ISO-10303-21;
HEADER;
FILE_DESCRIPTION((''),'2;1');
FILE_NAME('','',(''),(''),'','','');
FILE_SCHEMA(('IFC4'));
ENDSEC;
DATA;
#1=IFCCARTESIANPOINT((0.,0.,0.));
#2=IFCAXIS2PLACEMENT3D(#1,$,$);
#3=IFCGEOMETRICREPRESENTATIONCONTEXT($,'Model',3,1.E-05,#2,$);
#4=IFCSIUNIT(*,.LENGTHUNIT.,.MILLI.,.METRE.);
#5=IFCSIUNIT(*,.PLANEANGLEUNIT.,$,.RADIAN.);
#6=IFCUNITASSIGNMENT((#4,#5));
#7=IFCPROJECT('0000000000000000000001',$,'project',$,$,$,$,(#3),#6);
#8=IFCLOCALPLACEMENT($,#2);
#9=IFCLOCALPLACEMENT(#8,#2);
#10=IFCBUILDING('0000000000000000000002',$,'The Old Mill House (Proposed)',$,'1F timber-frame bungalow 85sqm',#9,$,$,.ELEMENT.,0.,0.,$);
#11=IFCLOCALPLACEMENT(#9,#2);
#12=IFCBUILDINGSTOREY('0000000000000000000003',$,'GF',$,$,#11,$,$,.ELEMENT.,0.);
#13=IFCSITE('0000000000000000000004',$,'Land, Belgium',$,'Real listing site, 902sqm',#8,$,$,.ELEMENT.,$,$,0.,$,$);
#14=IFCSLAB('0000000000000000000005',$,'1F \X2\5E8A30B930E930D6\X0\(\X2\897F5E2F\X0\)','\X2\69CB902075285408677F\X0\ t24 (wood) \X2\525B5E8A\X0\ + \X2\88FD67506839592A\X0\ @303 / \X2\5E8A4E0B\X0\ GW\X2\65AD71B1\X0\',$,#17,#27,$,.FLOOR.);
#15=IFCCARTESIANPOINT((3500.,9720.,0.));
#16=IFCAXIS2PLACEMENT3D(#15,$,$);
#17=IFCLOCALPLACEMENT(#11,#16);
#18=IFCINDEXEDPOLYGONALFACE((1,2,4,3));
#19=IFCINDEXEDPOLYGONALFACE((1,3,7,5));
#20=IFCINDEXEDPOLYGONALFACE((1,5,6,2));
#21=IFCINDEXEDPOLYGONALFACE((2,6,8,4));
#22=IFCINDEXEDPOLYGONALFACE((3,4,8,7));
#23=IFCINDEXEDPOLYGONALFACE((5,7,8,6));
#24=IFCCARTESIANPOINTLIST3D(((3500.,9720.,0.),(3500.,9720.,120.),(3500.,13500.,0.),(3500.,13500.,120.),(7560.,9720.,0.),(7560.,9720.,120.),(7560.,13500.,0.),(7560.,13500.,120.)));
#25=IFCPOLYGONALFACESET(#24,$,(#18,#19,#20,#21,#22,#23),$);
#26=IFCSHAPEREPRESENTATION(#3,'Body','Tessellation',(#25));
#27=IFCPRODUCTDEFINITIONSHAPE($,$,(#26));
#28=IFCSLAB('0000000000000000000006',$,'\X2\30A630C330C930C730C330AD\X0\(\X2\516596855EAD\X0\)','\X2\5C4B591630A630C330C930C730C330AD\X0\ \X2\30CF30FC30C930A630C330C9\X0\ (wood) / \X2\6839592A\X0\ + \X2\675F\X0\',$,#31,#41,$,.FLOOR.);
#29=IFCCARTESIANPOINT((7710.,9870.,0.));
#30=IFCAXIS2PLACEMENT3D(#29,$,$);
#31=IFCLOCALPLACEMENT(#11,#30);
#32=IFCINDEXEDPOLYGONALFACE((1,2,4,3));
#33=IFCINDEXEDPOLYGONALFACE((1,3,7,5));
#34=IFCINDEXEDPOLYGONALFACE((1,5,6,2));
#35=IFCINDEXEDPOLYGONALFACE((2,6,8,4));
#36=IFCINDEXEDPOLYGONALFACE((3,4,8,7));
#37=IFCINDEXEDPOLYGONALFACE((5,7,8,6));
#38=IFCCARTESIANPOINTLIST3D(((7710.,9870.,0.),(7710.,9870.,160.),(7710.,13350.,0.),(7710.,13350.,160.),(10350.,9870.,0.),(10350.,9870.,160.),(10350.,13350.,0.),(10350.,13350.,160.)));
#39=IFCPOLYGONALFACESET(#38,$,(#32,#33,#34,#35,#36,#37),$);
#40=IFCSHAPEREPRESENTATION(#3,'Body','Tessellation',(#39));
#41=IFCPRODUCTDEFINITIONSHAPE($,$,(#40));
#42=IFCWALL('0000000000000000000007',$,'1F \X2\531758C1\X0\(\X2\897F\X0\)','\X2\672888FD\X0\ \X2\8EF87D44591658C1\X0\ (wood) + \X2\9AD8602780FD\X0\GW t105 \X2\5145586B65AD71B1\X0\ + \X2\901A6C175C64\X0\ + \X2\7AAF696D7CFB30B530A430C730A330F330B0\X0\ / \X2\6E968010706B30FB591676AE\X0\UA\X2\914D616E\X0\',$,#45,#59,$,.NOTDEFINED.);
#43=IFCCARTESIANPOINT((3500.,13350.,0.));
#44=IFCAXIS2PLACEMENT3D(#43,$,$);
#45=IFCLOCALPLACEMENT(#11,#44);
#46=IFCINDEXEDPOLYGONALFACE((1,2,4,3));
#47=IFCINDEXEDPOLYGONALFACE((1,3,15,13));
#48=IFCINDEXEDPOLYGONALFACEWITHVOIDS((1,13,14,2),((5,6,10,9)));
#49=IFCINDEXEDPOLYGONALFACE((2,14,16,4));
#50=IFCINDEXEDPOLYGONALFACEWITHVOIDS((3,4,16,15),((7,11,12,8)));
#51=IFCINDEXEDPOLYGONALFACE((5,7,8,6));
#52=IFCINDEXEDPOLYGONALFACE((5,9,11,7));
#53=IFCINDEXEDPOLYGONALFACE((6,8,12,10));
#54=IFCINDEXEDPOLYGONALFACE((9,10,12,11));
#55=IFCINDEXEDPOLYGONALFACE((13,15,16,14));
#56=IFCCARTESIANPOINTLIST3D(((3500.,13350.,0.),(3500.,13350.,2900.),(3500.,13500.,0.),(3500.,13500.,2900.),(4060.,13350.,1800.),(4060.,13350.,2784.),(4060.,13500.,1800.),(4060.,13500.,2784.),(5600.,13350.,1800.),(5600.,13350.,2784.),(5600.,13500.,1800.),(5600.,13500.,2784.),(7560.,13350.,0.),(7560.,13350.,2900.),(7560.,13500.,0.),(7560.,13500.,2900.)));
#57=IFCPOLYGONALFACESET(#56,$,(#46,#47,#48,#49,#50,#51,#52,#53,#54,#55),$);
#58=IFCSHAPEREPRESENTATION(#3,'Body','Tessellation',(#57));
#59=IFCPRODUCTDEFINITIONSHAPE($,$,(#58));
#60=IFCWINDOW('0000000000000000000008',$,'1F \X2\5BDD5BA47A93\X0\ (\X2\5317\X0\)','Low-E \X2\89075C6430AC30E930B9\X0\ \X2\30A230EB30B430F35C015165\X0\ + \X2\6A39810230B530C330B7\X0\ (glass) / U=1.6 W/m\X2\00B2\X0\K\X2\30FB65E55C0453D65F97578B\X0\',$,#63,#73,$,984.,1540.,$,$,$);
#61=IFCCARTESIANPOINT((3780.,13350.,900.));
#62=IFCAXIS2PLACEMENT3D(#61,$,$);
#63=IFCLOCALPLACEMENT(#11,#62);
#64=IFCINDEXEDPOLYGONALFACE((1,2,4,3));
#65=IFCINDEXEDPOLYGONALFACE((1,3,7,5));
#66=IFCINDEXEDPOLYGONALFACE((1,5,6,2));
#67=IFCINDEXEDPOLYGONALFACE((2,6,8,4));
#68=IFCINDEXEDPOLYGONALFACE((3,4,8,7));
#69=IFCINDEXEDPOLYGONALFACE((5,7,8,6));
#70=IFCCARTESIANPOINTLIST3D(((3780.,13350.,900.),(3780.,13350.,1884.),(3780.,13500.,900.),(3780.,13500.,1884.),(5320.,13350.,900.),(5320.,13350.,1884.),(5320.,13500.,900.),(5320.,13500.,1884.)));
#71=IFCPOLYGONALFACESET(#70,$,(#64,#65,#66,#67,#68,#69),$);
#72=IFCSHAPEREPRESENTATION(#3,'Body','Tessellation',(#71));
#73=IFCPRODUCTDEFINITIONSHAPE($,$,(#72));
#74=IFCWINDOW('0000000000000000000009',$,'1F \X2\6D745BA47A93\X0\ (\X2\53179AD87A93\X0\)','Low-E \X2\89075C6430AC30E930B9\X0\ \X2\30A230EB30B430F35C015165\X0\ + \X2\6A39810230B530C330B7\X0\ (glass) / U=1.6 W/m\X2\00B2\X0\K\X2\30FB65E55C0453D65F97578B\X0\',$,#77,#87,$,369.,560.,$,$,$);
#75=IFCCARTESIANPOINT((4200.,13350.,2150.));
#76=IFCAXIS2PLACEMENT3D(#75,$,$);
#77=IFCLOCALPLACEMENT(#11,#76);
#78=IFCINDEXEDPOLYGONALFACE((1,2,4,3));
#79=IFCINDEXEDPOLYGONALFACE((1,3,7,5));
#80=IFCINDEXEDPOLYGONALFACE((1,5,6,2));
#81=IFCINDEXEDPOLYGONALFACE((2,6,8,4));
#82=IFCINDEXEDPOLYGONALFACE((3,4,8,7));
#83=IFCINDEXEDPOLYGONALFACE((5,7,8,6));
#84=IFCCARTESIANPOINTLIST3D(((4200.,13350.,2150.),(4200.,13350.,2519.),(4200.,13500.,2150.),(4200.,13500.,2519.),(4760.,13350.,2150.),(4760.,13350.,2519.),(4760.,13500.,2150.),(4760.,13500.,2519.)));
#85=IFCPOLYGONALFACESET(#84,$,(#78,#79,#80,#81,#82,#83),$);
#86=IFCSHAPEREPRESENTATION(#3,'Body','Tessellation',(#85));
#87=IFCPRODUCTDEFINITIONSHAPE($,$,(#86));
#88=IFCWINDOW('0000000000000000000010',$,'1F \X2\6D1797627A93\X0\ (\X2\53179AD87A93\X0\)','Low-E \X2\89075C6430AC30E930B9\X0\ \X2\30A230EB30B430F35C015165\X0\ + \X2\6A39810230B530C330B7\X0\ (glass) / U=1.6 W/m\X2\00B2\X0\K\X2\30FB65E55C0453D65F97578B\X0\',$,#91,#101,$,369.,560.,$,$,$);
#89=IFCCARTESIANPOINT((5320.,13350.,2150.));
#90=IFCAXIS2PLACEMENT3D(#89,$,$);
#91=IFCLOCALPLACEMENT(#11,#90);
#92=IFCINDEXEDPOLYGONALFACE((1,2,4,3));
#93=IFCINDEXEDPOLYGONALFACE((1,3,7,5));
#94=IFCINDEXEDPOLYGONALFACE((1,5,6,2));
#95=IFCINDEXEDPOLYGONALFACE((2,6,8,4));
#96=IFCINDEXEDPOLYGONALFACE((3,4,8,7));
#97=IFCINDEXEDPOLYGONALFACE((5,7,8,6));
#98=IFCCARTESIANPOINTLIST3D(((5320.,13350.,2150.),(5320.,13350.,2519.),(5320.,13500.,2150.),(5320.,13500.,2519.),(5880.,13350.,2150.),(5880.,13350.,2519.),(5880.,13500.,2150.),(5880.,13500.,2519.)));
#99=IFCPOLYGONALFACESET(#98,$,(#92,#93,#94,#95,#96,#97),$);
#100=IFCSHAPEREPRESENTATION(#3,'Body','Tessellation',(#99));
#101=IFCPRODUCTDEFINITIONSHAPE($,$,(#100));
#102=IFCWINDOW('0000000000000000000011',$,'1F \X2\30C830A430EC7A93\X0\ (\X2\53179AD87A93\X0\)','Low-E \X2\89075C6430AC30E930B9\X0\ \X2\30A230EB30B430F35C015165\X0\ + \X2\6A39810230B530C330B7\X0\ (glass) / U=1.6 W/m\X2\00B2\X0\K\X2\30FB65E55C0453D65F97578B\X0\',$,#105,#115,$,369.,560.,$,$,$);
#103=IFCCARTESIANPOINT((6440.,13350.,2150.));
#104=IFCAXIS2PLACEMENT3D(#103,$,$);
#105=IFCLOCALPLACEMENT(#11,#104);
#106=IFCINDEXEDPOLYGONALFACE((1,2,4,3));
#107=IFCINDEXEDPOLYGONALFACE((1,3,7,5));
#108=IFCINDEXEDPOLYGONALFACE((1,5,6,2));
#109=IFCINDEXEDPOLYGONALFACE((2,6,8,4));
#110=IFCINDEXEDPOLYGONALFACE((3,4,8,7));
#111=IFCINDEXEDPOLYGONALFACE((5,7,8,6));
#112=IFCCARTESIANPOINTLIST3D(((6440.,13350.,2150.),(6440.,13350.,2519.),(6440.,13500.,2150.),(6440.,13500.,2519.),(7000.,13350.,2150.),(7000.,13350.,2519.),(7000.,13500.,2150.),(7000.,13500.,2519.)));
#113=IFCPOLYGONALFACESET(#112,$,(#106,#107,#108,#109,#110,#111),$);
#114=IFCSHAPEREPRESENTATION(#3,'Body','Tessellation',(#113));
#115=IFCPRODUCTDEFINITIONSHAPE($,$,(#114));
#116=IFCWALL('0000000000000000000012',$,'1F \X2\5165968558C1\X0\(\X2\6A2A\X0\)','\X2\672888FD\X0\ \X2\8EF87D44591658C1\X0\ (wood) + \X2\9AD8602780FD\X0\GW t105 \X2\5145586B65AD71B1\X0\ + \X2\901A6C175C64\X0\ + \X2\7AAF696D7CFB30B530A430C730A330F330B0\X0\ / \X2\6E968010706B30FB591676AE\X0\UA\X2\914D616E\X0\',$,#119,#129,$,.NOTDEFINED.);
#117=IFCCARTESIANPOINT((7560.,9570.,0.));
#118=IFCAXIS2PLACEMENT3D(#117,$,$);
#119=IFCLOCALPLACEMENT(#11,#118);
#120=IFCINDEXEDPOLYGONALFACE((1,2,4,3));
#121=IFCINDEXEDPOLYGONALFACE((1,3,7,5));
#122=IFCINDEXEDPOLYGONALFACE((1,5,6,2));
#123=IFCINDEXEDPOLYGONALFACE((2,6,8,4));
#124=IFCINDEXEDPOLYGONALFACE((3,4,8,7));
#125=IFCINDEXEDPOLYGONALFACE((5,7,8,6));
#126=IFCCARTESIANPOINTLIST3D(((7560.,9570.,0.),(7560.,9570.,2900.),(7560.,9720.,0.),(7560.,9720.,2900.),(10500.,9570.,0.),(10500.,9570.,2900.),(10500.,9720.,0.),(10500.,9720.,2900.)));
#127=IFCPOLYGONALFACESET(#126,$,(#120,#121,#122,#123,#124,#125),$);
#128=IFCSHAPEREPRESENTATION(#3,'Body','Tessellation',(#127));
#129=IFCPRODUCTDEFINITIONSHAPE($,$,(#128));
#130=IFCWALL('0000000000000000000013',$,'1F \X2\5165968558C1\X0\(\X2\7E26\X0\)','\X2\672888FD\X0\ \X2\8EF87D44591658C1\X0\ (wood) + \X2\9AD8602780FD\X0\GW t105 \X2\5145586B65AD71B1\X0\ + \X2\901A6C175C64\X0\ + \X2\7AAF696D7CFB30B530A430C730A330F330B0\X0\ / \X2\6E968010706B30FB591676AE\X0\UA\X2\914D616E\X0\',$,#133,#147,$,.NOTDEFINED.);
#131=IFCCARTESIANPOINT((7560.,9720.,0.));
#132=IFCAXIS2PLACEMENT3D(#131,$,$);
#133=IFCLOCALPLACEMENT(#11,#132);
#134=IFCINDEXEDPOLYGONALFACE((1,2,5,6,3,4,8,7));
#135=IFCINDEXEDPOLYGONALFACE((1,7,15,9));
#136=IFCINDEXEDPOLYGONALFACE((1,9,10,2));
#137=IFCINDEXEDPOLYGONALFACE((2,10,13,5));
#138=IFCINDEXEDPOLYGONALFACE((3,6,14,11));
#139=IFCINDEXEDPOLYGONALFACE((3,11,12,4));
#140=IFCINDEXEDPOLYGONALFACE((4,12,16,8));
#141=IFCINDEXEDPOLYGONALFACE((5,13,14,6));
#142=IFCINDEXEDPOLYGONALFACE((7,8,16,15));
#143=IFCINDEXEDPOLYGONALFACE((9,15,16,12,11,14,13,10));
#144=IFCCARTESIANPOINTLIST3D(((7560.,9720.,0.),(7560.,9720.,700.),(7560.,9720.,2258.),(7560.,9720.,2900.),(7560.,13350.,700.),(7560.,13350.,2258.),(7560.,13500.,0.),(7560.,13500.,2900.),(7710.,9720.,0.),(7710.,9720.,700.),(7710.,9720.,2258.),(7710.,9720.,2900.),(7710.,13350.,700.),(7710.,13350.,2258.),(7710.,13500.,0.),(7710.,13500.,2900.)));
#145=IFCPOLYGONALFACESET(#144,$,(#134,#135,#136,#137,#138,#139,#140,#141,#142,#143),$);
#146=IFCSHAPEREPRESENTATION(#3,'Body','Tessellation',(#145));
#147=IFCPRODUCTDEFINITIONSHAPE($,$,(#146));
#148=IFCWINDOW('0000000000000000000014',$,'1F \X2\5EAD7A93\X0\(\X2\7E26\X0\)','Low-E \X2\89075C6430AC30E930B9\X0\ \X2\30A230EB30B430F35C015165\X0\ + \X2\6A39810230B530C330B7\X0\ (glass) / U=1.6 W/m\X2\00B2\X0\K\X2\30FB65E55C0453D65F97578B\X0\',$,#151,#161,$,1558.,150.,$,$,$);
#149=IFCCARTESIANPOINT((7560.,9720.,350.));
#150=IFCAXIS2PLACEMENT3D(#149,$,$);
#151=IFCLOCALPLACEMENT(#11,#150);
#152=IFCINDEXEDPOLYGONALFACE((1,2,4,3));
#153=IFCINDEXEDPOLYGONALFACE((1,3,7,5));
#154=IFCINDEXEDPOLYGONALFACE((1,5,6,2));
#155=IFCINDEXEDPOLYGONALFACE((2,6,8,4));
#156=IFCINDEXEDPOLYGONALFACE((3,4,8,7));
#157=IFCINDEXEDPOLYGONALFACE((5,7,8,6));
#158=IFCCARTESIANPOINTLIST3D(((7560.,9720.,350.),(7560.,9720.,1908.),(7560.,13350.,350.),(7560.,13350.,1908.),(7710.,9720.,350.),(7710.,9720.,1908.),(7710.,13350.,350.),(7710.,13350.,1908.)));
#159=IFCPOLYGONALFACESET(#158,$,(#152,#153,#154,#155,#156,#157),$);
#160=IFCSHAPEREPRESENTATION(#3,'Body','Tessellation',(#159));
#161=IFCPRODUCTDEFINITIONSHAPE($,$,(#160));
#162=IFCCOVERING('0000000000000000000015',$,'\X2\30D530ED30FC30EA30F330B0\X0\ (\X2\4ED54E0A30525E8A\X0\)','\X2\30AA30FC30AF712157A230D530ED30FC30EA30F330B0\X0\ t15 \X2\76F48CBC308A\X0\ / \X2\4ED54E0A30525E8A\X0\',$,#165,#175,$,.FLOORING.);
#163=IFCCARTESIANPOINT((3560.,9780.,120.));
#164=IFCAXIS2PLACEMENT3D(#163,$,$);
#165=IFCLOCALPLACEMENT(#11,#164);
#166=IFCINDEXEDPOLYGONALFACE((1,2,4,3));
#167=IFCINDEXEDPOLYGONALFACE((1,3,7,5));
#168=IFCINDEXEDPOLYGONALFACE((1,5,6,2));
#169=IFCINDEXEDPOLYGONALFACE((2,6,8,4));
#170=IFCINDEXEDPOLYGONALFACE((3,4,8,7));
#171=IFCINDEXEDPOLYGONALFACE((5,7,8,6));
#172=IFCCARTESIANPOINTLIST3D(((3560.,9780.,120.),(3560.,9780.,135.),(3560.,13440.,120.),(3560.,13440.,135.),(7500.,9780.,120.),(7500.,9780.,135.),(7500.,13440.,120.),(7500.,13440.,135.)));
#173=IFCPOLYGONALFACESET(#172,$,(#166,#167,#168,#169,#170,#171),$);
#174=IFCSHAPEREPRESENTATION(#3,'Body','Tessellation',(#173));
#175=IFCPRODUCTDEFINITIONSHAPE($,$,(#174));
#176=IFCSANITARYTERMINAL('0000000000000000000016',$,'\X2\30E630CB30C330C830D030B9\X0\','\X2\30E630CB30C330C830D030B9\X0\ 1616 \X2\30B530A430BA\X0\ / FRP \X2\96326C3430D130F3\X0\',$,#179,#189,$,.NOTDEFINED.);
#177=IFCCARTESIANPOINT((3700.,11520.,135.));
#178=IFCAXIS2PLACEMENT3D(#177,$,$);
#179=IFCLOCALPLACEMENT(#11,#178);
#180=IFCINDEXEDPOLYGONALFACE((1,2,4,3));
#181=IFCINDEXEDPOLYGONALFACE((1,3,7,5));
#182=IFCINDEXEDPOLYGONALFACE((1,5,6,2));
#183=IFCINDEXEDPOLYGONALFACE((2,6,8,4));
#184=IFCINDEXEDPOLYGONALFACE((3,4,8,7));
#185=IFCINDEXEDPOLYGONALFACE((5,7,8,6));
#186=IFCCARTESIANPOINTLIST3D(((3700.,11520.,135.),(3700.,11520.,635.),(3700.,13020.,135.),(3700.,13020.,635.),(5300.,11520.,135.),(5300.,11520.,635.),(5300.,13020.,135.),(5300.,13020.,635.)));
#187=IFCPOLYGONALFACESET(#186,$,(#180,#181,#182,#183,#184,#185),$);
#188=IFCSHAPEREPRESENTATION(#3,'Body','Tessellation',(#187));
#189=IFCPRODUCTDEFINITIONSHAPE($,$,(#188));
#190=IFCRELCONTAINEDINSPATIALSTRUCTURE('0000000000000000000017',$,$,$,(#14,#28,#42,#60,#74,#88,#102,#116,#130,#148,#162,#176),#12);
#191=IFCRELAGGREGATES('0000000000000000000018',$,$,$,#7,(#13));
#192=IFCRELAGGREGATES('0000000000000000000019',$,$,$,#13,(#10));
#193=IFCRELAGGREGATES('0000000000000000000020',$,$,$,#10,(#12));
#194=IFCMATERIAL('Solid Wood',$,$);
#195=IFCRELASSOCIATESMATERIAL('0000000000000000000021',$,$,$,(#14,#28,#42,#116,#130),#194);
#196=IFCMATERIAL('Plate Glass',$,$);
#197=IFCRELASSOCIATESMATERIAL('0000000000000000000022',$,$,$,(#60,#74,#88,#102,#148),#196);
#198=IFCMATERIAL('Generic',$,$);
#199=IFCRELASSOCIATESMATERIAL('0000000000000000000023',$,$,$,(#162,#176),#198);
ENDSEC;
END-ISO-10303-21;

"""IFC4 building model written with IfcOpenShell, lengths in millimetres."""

from ifc_helpers import new_model, si_unit, frame, frame_2d, origin, place, context, project, spatial, rectangle, extrude, material, element, fill, save


model = new_model("IFC4")

# Units and contexts
model_context = context("Model", 3, precision=1e-05, world=origin())
ifc_project = project(units=[si_unit("LENGTHUNIT", "METRE", prefix="MILLI"), si_unit("PLANEANGLEUNIT", "RADIAN")], contexts=[model_context])

# Site, building, storey
site_placement = place(None, origin())
site = spatial("IfcSite", under=ifc_project, at=site_placement, Name="Land, Belgium", ObjectType="Real listing site, 902sqm", CompositionType="ELEMENT", RefElevation=0.0)
building_placement = place(site_placement, origin())
building = spatial("IfcBuilding", under=site, at=building_placement, Name="The Old Mill House (Proposed)", ObjectType="1F timber-frame bungalow 85sqm", CompositionType="ELEMENT", ElevationOfRefHeight=0.0, ElevationOfTerrain=0.0)
storey_placement = place(building_placement, origin())
storey = spatial("IfcBuildingStorey", under=building, at=storey_placement, Name="GF", CompositionType="ELEMENT", Elevation=0.0)

# Slabs
ifc_material_1 = material(Name="Solid Wood")
slab_1_placement = place(storey_placement, frame((3500.0, 9720.0, 0.0)))
element("IfcSlab", 1, at=slab_1_placement, inside=storey, material=ifc_material_1, Name="1F 床スラブ(西帯)", Description="構造用合板 t24 (wood) 剛床 + 製材根太 @303 / 床下 GW断熱", PredefinedType="FLOOR", context=model_context, shape_type="SweptSolid", body=[
    extrude(rectangle(XDim=4060.0, YDim=3780.0, at=frame_2d((2030.0, 1890.0))), frame((3500.0, 9720.0, 0.0)), (0.0, 0.0, 1.0), 120.0),
])
slab_2_placement = place(storey_placement, frame((7710.0, 9870.0, 0.0)))
element("IfcSlab", 2, at=slab_2_placement, inside=storey, material=ifc_material_1, Name="ウッドデッキ(入隅庭)", Description="屋外ウッドデッキ ハードウッド (wood) / 根太 + 束", PredefinedType="FLOOR", context=model_context, shape_type="SweptSolid", body=[
    extrude(rectangle(XDim=2640.0, YDim=3480.0, at=frame_2d((1320.0, 1740.0))), frame((7710.0, 9870.0, 0.0)), (0.0, 0.0, 1.0), 160.0),
])

# Wall, openings, windows
wall_1_placement = place(storey_placement, frame((3500.0, 13350.0, 0.0)))
wall_1 = element("IfcWall", 3, at=wall_1_placement, inside=storey, material=ifc_material_1, Name="1F 北壁(西)", Description="木製 軸組外壁 (wood) + 高性能GW t105 充填断熱 + 通気層 + 窯業系サイディング / 準耐火・外皮UA配慮", PredefinedType="NOTDEFINED", context=model_context, shape_type="SweptSolid", body=[
    extrude(rectangle(XDim=4060.0, YDim=150.0, at=frame_2d((2030.0, 75.0))), frame((3500.0, 13350.0, 0.0)), (0.0, 0.0, 1.0), 2900.0),
])
opening_1_placement = place(storey_placement, frame((3780.0, 13350.0, 900.0)))
opening_1 = element("IfcOpeningElement", 4, at=opening_1_placement, cuts=wall_1, PredefinedType="NOTDEFINED", context=model_context, shape_type="SweptSolid", body=[
    extrude(rectangle(XDim=1540.0, YDim=150.0, at=frame_2d((770.0, 75.0))), frame((3780.0, 13350.0, 900.0)), (0.0, 0.0, 1.0), 984.0),
])
opening_2_placement = place(storey_placement, frame((4200.0, 13350.0, 2150.0)))
opening_2 = element("IfcOpeningElement", 5, at=opening_2_placement, cuts=wall_1, PredefinedType="NOTDEFINED", context=model_context, shape_type="SweptSolid", body=[
    extrude(rectangle(XDim=560.0, YDim=150.0, at=frame_2d((280.0, 75.0))), frame((4200.0, 13350.0, 2150.0)), (0.0, 0.0, 1.0), 369.0),
])
opening_3_placement = place(storey_placement, frame((5320.0, 13350.0, 2150.0)))
opening_3 = element("IfcOpeningElement", 6, at=opening_3_placement, cuts=wall_1, PredefinedType="NOTDEFINED", context=model_context, shape_type="SweptSolid", body=[
    extrude(rectangle(XDim=560.0, YDim=150.0, at=frame_2d((280.0, 75.0))), frame((5320.0, 13350.0, 2150.0)), (0.0, 0.0, 1.0), 369.0),
])
opening_4_placement = place(storey_placement, frame((6440.0, 13350.0, 2150.0)))
opening_4 = element("IfcOpeningElement", 7, at=opening_4_placement, cuts=wall_1, PredefinedType="NOTDEFINED", context=model_context, shape_type="SweptSolid", body=[
    extrude(rectangle(XDim=560.0, YDim=150.0, at=frame_2d((280.0, 75.0))), frame((6440.0, 13350.0, 2150.0)), (0.0, 0.0, 1.0), 369.0),
])
ifc_material_2 = material(Name="Plate Glass")
window_1_placement = place(storey_placement, frame((3780.0, 13350.0, 900.0)))
window_1 = element("IfcWindow", 8, at=window_1_placement, inside=storey, material=ifc_material_2, Name="1F 寝室窓 (北)", Description="Low-E 複層ガラス アルゴン封入 + 樹脂サッシ (glass) / U=1.6 W/m²K・日射取得型", OverallHeight=984.0, OverallWidth=1540.0, context=model_context, shape_type="SweptSolid", body=[
    extrude(rectangle(XDim=1540.0, YDim=150.0, at=frame_2d((770.0, 75.0))), frame((3780.0, 13350.0, 900.0)), (0.0, 0.0, 1.0), 984.0),
])
fill(opening_1, window_1)
window_2_placement = place(storey_placement, frame((4200.0, 13350.0, 2150.0)))
window_2 = element("IfcWindow", 9, at=window_2_placement, inside=storey, material=ifc_material_2, Name="1F 浴室窓 (北高窓)", Description="Low-E 複層ガラス アルゴン封入 + 樹脂サッシ (glass) / U=1.6 W/m²K・日射取得型", OverallHeight=369.0, OverallWidth=560.0, context=model_context, shape_type="SweptSolid", body=[
    extrude(rectangle(XDim=560.0, YDim=150.0, at=frame_2d((280.0, 75.0))), frame((4200.0, 13350.0, 2150.0)), (0.0, 0.0, 1.0), 369.0),
])
fill(opening_2, window_2)
window_3_placement = place(storey_placement, frame((5320.0, 13350.0, 2150.0)))
window_3 = element("IfcWindow", 10, at=window_3_placement, inside=storey, material=ifc_material_2, Name="1F 洗面窓 (北高窓)", Description="Low-E 複層ガラス アルゴン封入 + 樹脂サッシ (glass) / U=1.6 W/m²K・日射取得型", OverallHeight=369.0, OverallWidth=560.0, context=model_context, shape_type="SweptSolid", body=[
    extrude(rectangle(XDim=560.0, YDim=150.0, at=frame_2d((280.0, 75.0))), frame((5320.0, 13350.0, 2150.0)), (0.0, 0.0, 1.0), 369.0),
])
fill(opening_3, window_3)
window_4_placement = place(storey_placement, frame((6440.0, 13350.0, 2150.0)))
window_4 = element("IfcWindow", 11, at=window_4_placement, inside=storey, material=ifc_material_2, Name="1F トイレ窓 (北高窓)", Description="Low-E 複層ガラス アルゴン封入 + 樹脂サッシ (glass) / U=1.6 W/m²K・日射取得型", OverallHeight=369.0, OverallWidth=560.0, context=model_context, shape_type="SweptSolid", body=[
    extrude(rectangle(XDim=560.0, YDim=150.0, at=frame_2d((280.0, 75.0))), frame((6440.0, 13350.0, 2150.0)), (0.0, 0.0, 1.0), 369.0),
])
fill(opening_4, window_4)

# Wall
wall_2_placement = place(storey_placement, frame((7560.0, 9570.0, 0.0)))
element("IfcWall", 12, at=wall_2_placement, inside=storey, material=ifc_material_1, Name="1F 入隅壁(横)", Description="木製 軸組外壁 (wood) + 高性能GW t105 充填断熱 + 通気層 + 窯業系サイディング / 準耐火・外皮UA配慮", PredefinedType="NOTDEFINED", context=model_context, shape_type="SweptSolid", body=[
    extrude(rectangle(XDim=2940.0, YDim=150.0, at=frame_2d((1470.0, 75.0))), frame((7560.0, 9570.0, 0.0)), (0.0, 0.0, 1.0), 2900.0),
])

# Wall, opening, window
wall_3_placement = place(storey_placement, frame((7560.0, 9720.0, 0.0)))
wall_3 = element("IfcWall", 13, at=wall_3_placement, inside=storey, material=ifc_material_1, Name="1F 入隅壁(縦)", Description="木製 軸組外壁 (wood) + 高性能GW t105 充填断熱 + 通気層 + 窯業系サイディング / 準耐火・外皮UA配慮", PredefinedType="NOTDEFINED", context=model_context, shape_type="SweptSolid", body=[
    extrude(rectangle(XDim=150.0, YDim=3780.0, at=frame_2d((75.0, 1890.0))), frame((7560.0, 9720.0, 0.0)), (0.0, 0.0, 1.0), 2900.0),
])
opening_5_placement = place(storey_placement, frame((7560.0, 9720.0, 350.0)))
opening_5 = element("IfcOpeningElement", 14, at=opening_5_placement, cuts=wall_3, PredefinedType="NOTDEFINED", context=model_context, shape_type="SweptSolid", body=[
    extrude(rectangle(XDim=150.0, YDim=3630.0, at=frame_2d((75.0, 1815.0))), frame((7560.0, 9720.0, 350.0)), (0.0, 0.0, 1.0), 1558.0),
])
window_5_placement = place(storey_placement, frame((7560.0, 9720.0, 350.0)))
window_5 = element("IfcWindow", 15, at=window_5_placement, inside=storey, material=ifc_material_2, Name="1F 庭窓(縦)", Description="Low-E 複層ガラス アルゴン封入 + 樹脂サッシ (glass) / U=1.6 W/m²K・日射取得型", OverallHeight=1558.0, OverallWidth=150.0, context=model_context, shape_type="SweptSolid", body=[
    extrude(rectangle(XDim=150.0, YDim=3630.0, at=frame_2d((75.0, 1815.0))), frame((7560.0, 9720.0, 350.0)), (0.0, 0.0, 1.0), 1558.0),
])
fill(opening_5, window_5)

# Covering
ifc_material_3 = material(Name="Generic")
covering_placement = place(storey_placement, frame((3560.0, 9780.0, 120.0)))
element("IfcCovering", 16, at=covering_placement, inside=storey, material=ifc_material_3, Name="フローリング (仕上げ床)", Description="オーク無垢フローリング t15 直貼り / 仕上げ床", PredefinedType="FLOORING", context=model_context, shape_type="SweptSolid", body=[
    extrude(rectangle(XDim=3940.0, YDim=3660.0, at=frame_2d((1970.0, 1830.0))), frame((3560.0, 9780.0, 120.0)), (0.0, 0.0, 1.0), 15.0),
])

# Sanitary terminal
sanitary_terminal_1_placement = place(storey_placement, frame((3700.0, 11520.0, 135.0)))
element("IfcSanitaryTerminal", 17, at=sanitary_terminal_1_placement, inside=storey, material=ifc_material_3, Name="ユニットバス", Description="ユニットバス 1616 サイズ / FRP 防水パン", PredefinedType="NOTDEFINED", context=model_context, shape_type="SweptSolid", body=[
    extrude(rectangle(XDim=1600.0, YDim=1500.0, at=frame_2d((800.0, 750.0))), frame((3700.0, 11520.0, 135.0)), (0.0, 0.0, 1.0), 500.0),
])

save(model, "model.ifc")
